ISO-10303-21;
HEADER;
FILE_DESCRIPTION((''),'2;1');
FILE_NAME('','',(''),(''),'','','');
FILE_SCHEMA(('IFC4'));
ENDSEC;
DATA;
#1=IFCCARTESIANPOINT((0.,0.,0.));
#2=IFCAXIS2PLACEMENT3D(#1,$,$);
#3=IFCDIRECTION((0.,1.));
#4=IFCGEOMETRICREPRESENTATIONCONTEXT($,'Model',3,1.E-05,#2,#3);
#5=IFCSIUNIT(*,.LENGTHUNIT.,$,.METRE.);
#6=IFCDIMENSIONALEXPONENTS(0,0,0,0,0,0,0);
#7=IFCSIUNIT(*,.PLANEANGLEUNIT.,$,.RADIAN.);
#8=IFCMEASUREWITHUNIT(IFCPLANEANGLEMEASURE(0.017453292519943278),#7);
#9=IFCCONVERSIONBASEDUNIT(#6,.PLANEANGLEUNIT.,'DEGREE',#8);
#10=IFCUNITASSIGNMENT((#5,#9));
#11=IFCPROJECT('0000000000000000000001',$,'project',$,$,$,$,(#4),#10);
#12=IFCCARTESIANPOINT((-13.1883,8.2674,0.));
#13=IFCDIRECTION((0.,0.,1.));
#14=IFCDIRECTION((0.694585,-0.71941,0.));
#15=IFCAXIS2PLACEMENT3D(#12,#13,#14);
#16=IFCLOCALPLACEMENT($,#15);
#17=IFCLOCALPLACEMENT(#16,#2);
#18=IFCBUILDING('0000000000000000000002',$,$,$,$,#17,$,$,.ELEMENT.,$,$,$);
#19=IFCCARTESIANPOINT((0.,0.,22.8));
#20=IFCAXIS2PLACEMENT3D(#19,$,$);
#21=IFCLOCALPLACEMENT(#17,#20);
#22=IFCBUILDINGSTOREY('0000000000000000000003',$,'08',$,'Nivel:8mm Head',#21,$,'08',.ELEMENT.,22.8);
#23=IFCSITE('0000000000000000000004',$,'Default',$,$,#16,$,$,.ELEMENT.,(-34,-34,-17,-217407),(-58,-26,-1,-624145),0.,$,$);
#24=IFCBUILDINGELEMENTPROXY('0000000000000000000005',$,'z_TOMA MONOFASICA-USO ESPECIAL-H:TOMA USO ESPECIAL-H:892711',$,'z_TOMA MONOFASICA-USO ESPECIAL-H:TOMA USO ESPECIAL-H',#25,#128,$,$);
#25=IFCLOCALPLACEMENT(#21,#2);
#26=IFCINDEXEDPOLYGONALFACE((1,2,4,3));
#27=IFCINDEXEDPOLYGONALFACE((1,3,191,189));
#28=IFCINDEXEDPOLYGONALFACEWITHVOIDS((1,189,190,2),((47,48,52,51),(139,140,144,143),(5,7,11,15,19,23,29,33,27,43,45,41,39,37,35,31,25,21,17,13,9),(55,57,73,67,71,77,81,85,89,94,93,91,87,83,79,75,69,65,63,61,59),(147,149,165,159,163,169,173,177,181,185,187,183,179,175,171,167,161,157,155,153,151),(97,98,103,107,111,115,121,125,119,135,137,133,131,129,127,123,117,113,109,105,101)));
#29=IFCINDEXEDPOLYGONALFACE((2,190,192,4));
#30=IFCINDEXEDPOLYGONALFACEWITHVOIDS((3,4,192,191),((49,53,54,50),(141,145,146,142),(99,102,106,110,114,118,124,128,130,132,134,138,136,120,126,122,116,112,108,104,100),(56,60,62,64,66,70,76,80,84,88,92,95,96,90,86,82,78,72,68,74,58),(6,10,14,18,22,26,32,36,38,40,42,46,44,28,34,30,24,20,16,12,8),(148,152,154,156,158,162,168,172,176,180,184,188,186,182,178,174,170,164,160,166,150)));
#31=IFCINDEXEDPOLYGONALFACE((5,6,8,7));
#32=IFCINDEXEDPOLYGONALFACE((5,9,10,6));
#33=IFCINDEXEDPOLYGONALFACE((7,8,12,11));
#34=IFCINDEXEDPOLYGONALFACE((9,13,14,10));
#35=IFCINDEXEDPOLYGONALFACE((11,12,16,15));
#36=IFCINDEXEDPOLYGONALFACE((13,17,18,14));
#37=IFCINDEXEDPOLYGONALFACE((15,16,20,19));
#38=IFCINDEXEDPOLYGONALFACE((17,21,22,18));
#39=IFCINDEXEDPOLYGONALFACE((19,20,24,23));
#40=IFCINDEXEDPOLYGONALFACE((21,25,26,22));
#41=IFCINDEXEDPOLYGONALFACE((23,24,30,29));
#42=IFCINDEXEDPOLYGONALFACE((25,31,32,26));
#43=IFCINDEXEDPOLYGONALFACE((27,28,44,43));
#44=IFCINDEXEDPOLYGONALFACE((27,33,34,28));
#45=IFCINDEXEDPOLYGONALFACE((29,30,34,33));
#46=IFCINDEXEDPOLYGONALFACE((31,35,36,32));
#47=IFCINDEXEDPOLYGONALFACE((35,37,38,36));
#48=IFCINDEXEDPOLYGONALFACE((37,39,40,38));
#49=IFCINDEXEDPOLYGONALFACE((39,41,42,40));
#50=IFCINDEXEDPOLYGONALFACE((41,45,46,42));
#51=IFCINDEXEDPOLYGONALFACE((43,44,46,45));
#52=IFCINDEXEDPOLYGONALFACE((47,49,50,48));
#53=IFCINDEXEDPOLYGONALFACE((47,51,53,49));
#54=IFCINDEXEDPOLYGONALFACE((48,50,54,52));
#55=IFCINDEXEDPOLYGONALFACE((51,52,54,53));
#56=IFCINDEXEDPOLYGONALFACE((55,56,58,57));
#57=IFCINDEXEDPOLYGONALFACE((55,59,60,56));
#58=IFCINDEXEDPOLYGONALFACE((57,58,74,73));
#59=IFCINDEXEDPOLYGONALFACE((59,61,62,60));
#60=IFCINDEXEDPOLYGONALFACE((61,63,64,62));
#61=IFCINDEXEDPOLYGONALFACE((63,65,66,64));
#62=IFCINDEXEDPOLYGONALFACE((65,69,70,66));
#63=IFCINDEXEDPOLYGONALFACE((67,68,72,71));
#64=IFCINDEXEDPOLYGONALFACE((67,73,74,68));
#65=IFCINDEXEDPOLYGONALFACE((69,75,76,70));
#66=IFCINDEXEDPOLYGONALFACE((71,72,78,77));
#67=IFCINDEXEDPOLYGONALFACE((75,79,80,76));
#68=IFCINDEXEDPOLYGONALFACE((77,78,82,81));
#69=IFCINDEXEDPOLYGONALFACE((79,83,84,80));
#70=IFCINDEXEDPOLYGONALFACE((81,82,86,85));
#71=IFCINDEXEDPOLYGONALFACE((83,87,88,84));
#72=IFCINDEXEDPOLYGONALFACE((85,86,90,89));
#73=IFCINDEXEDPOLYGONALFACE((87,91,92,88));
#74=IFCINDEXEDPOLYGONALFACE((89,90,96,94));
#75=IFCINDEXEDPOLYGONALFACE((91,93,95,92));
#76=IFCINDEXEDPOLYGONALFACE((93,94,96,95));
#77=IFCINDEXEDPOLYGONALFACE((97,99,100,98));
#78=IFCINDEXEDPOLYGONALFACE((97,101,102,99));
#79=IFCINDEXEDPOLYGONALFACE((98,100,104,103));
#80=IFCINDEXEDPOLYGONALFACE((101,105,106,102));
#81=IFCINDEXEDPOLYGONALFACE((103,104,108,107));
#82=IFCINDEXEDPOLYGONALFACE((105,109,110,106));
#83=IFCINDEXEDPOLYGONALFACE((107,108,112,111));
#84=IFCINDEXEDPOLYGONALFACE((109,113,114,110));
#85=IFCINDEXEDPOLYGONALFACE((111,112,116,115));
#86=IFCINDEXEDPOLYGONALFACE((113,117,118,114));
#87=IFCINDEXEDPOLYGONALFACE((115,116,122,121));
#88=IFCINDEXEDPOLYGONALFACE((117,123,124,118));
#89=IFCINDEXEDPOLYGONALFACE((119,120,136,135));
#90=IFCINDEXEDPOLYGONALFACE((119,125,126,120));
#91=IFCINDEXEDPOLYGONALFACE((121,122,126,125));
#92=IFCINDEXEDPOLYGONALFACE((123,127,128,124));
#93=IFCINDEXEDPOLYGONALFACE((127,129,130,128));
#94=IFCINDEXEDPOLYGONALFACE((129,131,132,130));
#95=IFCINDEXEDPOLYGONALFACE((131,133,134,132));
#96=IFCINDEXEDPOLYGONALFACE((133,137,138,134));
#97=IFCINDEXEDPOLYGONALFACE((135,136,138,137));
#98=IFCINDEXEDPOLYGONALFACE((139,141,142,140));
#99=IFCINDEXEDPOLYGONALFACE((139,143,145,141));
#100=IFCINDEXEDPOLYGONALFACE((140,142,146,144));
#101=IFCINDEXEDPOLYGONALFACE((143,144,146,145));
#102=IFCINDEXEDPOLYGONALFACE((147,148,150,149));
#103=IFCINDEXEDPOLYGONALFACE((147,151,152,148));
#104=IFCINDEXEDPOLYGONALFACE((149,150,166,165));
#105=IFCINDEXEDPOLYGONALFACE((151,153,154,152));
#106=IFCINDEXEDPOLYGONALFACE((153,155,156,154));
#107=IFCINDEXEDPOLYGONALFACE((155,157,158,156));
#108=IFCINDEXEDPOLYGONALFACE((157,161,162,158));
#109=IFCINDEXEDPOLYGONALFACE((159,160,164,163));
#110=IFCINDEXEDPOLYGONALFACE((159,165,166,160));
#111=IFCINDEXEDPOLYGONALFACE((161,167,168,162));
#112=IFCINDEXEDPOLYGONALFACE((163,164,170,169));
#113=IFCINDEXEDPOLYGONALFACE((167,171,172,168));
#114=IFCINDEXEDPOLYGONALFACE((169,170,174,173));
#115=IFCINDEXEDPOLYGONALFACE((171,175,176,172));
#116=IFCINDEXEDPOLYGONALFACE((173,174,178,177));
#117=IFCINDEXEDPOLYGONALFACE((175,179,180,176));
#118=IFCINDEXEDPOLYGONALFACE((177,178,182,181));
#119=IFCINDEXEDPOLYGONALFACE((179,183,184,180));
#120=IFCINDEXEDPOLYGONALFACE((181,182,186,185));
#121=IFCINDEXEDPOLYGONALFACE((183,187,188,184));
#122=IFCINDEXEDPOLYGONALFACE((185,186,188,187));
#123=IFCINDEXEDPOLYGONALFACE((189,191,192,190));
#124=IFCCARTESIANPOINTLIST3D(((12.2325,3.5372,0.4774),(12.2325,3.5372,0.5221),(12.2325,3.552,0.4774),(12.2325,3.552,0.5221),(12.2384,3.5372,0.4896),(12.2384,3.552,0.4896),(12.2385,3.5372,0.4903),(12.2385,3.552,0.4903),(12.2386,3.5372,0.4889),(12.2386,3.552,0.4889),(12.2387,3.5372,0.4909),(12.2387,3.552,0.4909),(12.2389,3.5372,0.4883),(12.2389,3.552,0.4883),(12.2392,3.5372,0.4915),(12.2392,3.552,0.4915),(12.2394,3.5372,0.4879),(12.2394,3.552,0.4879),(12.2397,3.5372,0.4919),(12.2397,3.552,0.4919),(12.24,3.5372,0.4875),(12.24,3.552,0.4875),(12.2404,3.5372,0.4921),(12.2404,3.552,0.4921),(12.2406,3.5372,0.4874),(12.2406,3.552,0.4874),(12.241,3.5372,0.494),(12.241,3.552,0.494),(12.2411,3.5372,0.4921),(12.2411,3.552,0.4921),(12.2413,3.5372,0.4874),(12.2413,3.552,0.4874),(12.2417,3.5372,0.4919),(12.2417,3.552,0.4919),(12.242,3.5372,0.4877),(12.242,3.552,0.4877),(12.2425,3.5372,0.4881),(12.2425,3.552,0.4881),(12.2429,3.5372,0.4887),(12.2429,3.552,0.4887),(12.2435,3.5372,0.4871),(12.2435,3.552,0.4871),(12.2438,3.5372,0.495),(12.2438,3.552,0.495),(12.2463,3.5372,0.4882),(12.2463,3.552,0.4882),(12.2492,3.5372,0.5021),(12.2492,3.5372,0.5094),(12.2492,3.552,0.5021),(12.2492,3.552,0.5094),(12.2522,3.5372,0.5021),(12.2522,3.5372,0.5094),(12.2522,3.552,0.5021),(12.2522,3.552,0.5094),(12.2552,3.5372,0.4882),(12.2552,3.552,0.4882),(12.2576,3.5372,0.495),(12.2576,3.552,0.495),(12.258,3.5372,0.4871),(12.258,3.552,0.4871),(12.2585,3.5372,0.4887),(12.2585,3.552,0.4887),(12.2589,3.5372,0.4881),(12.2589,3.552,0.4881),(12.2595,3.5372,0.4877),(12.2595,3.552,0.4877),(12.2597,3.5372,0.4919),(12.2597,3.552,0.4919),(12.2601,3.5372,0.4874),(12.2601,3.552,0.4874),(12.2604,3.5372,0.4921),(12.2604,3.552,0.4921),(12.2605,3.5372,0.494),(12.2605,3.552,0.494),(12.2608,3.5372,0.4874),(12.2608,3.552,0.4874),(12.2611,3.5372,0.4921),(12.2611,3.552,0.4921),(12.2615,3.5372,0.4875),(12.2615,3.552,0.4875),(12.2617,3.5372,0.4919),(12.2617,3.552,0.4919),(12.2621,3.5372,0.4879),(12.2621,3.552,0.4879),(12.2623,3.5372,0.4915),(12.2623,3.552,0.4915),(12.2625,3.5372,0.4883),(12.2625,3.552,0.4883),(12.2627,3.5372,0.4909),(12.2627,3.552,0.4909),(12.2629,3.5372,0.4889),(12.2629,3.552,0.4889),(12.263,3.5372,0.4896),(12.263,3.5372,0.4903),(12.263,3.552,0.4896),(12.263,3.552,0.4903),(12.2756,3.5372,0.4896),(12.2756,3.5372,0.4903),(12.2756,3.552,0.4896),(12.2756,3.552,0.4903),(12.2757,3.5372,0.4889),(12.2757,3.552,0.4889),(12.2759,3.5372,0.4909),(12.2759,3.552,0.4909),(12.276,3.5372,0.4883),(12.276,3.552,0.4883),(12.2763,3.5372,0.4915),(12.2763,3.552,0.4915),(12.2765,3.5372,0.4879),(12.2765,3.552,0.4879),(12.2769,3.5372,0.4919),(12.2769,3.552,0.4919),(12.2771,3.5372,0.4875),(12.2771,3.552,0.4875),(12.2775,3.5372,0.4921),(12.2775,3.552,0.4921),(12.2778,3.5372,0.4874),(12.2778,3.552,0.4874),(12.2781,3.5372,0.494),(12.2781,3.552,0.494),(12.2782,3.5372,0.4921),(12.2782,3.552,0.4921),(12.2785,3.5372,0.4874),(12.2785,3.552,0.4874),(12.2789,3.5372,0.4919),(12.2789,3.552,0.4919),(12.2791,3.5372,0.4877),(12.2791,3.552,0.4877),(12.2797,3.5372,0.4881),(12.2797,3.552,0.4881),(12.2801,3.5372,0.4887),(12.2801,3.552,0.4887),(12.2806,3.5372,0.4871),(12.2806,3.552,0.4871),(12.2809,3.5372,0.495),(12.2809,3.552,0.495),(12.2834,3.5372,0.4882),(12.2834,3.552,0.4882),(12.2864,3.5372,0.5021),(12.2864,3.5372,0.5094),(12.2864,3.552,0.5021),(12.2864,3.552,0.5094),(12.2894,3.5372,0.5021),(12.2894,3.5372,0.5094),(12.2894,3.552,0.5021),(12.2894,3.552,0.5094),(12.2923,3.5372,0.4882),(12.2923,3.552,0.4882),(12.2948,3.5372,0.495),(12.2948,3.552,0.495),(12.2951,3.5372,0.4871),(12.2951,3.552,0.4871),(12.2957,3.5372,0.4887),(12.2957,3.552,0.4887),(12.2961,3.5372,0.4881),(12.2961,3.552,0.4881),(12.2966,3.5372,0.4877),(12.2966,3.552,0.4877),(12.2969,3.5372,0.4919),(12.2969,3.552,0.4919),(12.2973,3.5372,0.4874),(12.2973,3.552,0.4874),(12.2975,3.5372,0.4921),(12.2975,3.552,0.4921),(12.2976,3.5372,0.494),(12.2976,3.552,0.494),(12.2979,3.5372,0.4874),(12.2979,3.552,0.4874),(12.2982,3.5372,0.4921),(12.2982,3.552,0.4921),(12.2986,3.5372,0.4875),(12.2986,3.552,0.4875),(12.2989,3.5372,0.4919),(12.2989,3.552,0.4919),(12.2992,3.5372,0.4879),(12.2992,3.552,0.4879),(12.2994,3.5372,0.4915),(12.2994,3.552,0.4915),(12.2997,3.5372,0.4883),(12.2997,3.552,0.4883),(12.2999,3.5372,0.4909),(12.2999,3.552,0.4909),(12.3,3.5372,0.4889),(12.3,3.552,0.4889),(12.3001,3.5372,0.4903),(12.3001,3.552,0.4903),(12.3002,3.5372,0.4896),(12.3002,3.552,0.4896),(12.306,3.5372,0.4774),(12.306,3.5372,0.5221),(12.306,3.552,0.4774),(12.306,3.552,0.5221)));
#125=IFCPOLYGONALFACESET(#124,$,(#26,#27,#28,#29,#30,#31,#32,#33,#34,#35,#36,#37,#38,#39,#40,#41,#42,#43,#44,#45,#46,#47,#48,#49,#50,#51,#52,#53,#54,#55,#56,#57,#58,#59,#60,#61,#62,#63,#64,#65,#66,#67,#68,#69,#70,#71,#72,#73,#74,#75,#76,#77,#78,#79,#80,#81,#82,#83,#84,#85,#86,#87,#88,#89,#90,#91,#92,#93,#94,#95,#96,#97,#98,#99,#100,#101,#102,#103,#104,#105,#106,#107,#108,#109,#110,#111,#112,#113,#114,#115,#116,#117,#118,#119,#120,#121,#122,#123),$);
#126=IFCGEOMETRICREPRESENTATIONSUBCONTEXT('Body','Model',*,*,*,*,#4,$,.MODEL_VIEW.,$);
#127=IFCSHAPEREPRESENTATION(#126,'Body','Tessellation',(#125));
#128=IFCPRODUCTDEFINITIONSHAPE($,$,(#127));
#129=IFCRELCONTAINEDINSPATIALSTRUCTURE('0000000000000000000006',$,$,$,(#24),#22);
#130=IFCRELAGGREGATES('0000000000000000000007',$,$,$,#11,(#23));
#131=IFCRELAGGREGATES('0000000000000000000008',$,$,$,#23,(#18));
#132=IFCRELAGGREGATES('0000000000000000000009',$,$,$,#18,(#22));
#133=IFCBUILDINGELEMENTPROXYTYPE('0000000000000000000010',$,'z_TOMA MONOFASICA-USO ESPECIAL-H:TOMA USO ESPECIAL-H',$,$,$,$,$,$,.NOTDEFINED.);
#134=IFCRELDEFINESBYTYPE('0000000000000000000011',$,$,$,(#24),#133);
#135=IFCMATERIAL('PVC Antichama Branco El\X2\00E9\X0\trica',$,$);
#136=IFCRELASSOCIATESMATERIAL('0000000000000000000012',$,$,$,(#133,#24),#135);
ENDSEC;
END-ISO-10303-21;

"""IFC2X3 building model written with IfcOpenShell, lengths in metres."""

from ifc_helpers import new_model, entity, si_unit, converted_unit, direction, frame, frame_2d, origin, place, context, subcontext, project, spatial, polyline, circle_curve, parameter, trimmed, segment, composite_curve, outline, extrude, source, transform, mapped, material, type_object, type_shapes, element, save


model = new_model("IFC2X3")

# Units and contexts
model_context = context("Model", 3, precision=1e-05, world=origin(), true_north=direction((0.0, 1.0)))
body_context = subcontext(model_context, "Body", "Model", "MODEL_VIEW")
ifc_project = project(units=[si_unit("LENGTHUNIT", "METRE"), converted_unit("PLANEANGLEUNIT", "DEGREE", entity("IfcPlaneAngleMeasure", 0.017453292519943278), si_unit("PLANEANGLEUNIT", "RADIAN"), dimensions=[0, 0, 0, 0, 0, 0, 0])], contexts=[model_context])

# Site, building, storey
site_placement = place(None, frame((-13.1883, 8.2674, 0.0), z_axis=(0.0, 0.0, 1.0), x_axis=(0.694585, -0.71941, 0.0)))
site = spatial("IfcSite", under=ifc_project, at=site_placement, Name="Default", CompositionType="ELEMENT", RefLatitude=(-34, -34, -17, -217407), RefLongitude=(-58, -26, -1, -624145), RefElevation=0.0)
building_placement = place(site_placement, origin())
building = spatial("IfcBuilding", under=site, at=building_placement, CompositionType="ELEMENT")
storey_placement = place(building_placement, frame((0.0, 0.0, 22.8)))
storey = spatial("IfcBuildingStorey", under=building, at=storey_placement, Name="08", ObjectType="Nivel:8mm Head", LongName="08", CompositionType="ELEMENT", Elevation=22.8)

# Building element proxy
ifc_material_1 = material(Name="PVC Antichama Branco Elétrica")
building_element_proxy_type_1 = type_object("IfcBuildingElementProxyType", Name="z_TOMA MONOFASICA-USO ESPECIAL-H:TOMA USO ESPECIAL-H", PredefinedType="NOTDEFINED", material=ifc_material_1)
shared_shape_1 = source(origin(), body_context, "Body", "SweptSolid", [
    extrude(outline(polyline([(-0.0368, -0.0223), (0.0368, -0.0223), (0.0368, 0.0223), (-0.0368, 0.0223), (-0.0368, -0.0223)]), holes=[composite_curve([segment(polyline([(0.0141, 0.0115), (0.0116, 0.0047)]), True, "CONTINUOUS"), segment(polyline([(0.0116, 0.0047), (0.0088, 0.0057)]), True, "CONTINUOUS"), segment(polyline([(0.0088, 0.0057), (0.0096, 0.0078)]), True, "CONTINUOUS"), segment(trimmed(circle_curve(frame_2d((0.0087, 0.0099), x_axis=(1.0, 0.0)), 0.0024), [parameter(27.118901)], [parameter(292.881099)], True, "PARAMETER"), False, "CONTINUOUS"), segment(polyline([(0.0108, 0.011), (0.0113, 0.0126)]), True, "CONTINUOUS"), segment(polyline([(0.0113, 0.0126), (0.0141, 0.0115)]), True, "CONTINUOUS")], self_intersect=False), composite_curve([segment(polyline([(0.0255, 0.0047), (0.023, 0.0115)]), True, "CONTINUOUS"), segment(polyline([(0.023, 0.0115), (0.0258, 0.0126)]), True, "CONTINUOUS"), segment(polyline([(0.0258, 0.0126), (0.0264, 0.011)]), True, "CONTINUOUS"), segment(trimmed(circle_curve(frame_2d((0.0285, 0.0099), x_axis=(1.0, 0.0)), 0.0024), [parameter(247.118901)], [parameter(152.881099)], True, "PARAMETER"), False, "CONTINUOUS"), segment(polyline([(0.0276, 0.0078), (0.0283, 0.0057)]), True, "CONTINUOUS"), segment(polyline([(0.0283, 0.0057), (0.0255, 0.0047)]), True, "CONTINUOUS")], self_intersect=False), polyline([(0.0201, -0.0024), (0.0201, -0.0097), (0.0171, -0.0097), (0.0171, -0.0024), (0.0201, -0.0024)]), composite_curve([segment(polyline([(-0.0141, 0.0115), (-0.0113, 0.0126)]), True, "CONTINUOUS"), segment(polyline([(-0.0113, 0.0126), (-0.0108, 0.011)]), True, "CONTINUOUS"), segment(trimmed(circle_curve(frame_2d((-0.0087, 0.0099), x_axis=(1.0, 0.0)), 0.0024), [parameter(247.118901)], [parameter(152.881099)], True, "PARAMETER"), False, "CONTINUOUS"), segment(polyline([(-0.0096, 0.0078), (-0.0088, 0.0057)]), True, "CONTINUOUS"), segment(polyline([(-0.0088, 0.0057), (-0.0116, 0.0047)]), True, "CONTINUOUS"), segment(polyline([(-0.0116, 0.0047), (-0.0141, 0.0115)]), True, "CONTINUOUS")], self_intersect=False), composite_curve([segment(polyline([(-0.0255, 0.0047), (-0.0283, 0.0057)]), True, "CONTINUOUS"), segment(polyline([(-0.0283, 0.0057), (-0.0276, 0.0078)]), True, "CONTINUOUS"), segment(trimmed(circle_curve(frame_2d((-0.0285, 0.0099), x_axis=(1.0, 0.0)), 0.0024), [parameter(27.118901)], [parameter(292.881099)], True, "PARAMETER"), False, "CONTINUOUS"), segment(polyline([(-0.0264, 0.011), (-0.0258, 0.0126)]), True, "CONTINUOUS"), segment(polyline([(-0.0258, 0.0126), (-0.023, 0.0115)]), True, "CONTINUOUS"), segment(polyline([(-0.023, 0.0115), (-0.0255, 0.0047)]), True, "CONTINUOUS")], self_intersect=False), polyline([(-0.0201, -0.0024), (-0.0171, -0.0024), (-0.0171, -0.0097), (-0.0201, -0.0097), (-0.0201, -0.0024)])]), frame((0.0, -0.005, 0.0223), z_axis=(0.0, 1.0, 0.0), x_axis=(1.0, 0.0, 0.0)), (0.0, 0.0, 1.0), 0.0148),
])
type_shapes(building_element_proxy_type_1, [shared_shape_1])
for number, where, z_axis, x_axis, name in (
    (1, (12.2693, 3.547, 0.4774), (0.0, 0.0, 1.0), (-1.0, 0.0, 0.0), "z_TOMA MONOFASICA-USO ESPECIAL-H:TOMA USO ESPECIAL-H:892711"),
):
    element("IfcBuildingElementProxy", number, at=place(storey_placement, frame(where, z_axis=z_axis, x_axis=x_axis)), inside=storey, type_object=building_element_proxy_type_1, material=ifc_material_1, Name=name, ObjectType="z_TOMA MONOFASICA-USO ESPECIAL-H:TOMA USO ESPECIAL-H", context=body_context, shape_type="MappedRepresentation", body=[
        mapped(shared_shape_1, transform((0.0, 0.0, 0.0), scale=1.0)),
    ])

save(model, "model.ifc")
